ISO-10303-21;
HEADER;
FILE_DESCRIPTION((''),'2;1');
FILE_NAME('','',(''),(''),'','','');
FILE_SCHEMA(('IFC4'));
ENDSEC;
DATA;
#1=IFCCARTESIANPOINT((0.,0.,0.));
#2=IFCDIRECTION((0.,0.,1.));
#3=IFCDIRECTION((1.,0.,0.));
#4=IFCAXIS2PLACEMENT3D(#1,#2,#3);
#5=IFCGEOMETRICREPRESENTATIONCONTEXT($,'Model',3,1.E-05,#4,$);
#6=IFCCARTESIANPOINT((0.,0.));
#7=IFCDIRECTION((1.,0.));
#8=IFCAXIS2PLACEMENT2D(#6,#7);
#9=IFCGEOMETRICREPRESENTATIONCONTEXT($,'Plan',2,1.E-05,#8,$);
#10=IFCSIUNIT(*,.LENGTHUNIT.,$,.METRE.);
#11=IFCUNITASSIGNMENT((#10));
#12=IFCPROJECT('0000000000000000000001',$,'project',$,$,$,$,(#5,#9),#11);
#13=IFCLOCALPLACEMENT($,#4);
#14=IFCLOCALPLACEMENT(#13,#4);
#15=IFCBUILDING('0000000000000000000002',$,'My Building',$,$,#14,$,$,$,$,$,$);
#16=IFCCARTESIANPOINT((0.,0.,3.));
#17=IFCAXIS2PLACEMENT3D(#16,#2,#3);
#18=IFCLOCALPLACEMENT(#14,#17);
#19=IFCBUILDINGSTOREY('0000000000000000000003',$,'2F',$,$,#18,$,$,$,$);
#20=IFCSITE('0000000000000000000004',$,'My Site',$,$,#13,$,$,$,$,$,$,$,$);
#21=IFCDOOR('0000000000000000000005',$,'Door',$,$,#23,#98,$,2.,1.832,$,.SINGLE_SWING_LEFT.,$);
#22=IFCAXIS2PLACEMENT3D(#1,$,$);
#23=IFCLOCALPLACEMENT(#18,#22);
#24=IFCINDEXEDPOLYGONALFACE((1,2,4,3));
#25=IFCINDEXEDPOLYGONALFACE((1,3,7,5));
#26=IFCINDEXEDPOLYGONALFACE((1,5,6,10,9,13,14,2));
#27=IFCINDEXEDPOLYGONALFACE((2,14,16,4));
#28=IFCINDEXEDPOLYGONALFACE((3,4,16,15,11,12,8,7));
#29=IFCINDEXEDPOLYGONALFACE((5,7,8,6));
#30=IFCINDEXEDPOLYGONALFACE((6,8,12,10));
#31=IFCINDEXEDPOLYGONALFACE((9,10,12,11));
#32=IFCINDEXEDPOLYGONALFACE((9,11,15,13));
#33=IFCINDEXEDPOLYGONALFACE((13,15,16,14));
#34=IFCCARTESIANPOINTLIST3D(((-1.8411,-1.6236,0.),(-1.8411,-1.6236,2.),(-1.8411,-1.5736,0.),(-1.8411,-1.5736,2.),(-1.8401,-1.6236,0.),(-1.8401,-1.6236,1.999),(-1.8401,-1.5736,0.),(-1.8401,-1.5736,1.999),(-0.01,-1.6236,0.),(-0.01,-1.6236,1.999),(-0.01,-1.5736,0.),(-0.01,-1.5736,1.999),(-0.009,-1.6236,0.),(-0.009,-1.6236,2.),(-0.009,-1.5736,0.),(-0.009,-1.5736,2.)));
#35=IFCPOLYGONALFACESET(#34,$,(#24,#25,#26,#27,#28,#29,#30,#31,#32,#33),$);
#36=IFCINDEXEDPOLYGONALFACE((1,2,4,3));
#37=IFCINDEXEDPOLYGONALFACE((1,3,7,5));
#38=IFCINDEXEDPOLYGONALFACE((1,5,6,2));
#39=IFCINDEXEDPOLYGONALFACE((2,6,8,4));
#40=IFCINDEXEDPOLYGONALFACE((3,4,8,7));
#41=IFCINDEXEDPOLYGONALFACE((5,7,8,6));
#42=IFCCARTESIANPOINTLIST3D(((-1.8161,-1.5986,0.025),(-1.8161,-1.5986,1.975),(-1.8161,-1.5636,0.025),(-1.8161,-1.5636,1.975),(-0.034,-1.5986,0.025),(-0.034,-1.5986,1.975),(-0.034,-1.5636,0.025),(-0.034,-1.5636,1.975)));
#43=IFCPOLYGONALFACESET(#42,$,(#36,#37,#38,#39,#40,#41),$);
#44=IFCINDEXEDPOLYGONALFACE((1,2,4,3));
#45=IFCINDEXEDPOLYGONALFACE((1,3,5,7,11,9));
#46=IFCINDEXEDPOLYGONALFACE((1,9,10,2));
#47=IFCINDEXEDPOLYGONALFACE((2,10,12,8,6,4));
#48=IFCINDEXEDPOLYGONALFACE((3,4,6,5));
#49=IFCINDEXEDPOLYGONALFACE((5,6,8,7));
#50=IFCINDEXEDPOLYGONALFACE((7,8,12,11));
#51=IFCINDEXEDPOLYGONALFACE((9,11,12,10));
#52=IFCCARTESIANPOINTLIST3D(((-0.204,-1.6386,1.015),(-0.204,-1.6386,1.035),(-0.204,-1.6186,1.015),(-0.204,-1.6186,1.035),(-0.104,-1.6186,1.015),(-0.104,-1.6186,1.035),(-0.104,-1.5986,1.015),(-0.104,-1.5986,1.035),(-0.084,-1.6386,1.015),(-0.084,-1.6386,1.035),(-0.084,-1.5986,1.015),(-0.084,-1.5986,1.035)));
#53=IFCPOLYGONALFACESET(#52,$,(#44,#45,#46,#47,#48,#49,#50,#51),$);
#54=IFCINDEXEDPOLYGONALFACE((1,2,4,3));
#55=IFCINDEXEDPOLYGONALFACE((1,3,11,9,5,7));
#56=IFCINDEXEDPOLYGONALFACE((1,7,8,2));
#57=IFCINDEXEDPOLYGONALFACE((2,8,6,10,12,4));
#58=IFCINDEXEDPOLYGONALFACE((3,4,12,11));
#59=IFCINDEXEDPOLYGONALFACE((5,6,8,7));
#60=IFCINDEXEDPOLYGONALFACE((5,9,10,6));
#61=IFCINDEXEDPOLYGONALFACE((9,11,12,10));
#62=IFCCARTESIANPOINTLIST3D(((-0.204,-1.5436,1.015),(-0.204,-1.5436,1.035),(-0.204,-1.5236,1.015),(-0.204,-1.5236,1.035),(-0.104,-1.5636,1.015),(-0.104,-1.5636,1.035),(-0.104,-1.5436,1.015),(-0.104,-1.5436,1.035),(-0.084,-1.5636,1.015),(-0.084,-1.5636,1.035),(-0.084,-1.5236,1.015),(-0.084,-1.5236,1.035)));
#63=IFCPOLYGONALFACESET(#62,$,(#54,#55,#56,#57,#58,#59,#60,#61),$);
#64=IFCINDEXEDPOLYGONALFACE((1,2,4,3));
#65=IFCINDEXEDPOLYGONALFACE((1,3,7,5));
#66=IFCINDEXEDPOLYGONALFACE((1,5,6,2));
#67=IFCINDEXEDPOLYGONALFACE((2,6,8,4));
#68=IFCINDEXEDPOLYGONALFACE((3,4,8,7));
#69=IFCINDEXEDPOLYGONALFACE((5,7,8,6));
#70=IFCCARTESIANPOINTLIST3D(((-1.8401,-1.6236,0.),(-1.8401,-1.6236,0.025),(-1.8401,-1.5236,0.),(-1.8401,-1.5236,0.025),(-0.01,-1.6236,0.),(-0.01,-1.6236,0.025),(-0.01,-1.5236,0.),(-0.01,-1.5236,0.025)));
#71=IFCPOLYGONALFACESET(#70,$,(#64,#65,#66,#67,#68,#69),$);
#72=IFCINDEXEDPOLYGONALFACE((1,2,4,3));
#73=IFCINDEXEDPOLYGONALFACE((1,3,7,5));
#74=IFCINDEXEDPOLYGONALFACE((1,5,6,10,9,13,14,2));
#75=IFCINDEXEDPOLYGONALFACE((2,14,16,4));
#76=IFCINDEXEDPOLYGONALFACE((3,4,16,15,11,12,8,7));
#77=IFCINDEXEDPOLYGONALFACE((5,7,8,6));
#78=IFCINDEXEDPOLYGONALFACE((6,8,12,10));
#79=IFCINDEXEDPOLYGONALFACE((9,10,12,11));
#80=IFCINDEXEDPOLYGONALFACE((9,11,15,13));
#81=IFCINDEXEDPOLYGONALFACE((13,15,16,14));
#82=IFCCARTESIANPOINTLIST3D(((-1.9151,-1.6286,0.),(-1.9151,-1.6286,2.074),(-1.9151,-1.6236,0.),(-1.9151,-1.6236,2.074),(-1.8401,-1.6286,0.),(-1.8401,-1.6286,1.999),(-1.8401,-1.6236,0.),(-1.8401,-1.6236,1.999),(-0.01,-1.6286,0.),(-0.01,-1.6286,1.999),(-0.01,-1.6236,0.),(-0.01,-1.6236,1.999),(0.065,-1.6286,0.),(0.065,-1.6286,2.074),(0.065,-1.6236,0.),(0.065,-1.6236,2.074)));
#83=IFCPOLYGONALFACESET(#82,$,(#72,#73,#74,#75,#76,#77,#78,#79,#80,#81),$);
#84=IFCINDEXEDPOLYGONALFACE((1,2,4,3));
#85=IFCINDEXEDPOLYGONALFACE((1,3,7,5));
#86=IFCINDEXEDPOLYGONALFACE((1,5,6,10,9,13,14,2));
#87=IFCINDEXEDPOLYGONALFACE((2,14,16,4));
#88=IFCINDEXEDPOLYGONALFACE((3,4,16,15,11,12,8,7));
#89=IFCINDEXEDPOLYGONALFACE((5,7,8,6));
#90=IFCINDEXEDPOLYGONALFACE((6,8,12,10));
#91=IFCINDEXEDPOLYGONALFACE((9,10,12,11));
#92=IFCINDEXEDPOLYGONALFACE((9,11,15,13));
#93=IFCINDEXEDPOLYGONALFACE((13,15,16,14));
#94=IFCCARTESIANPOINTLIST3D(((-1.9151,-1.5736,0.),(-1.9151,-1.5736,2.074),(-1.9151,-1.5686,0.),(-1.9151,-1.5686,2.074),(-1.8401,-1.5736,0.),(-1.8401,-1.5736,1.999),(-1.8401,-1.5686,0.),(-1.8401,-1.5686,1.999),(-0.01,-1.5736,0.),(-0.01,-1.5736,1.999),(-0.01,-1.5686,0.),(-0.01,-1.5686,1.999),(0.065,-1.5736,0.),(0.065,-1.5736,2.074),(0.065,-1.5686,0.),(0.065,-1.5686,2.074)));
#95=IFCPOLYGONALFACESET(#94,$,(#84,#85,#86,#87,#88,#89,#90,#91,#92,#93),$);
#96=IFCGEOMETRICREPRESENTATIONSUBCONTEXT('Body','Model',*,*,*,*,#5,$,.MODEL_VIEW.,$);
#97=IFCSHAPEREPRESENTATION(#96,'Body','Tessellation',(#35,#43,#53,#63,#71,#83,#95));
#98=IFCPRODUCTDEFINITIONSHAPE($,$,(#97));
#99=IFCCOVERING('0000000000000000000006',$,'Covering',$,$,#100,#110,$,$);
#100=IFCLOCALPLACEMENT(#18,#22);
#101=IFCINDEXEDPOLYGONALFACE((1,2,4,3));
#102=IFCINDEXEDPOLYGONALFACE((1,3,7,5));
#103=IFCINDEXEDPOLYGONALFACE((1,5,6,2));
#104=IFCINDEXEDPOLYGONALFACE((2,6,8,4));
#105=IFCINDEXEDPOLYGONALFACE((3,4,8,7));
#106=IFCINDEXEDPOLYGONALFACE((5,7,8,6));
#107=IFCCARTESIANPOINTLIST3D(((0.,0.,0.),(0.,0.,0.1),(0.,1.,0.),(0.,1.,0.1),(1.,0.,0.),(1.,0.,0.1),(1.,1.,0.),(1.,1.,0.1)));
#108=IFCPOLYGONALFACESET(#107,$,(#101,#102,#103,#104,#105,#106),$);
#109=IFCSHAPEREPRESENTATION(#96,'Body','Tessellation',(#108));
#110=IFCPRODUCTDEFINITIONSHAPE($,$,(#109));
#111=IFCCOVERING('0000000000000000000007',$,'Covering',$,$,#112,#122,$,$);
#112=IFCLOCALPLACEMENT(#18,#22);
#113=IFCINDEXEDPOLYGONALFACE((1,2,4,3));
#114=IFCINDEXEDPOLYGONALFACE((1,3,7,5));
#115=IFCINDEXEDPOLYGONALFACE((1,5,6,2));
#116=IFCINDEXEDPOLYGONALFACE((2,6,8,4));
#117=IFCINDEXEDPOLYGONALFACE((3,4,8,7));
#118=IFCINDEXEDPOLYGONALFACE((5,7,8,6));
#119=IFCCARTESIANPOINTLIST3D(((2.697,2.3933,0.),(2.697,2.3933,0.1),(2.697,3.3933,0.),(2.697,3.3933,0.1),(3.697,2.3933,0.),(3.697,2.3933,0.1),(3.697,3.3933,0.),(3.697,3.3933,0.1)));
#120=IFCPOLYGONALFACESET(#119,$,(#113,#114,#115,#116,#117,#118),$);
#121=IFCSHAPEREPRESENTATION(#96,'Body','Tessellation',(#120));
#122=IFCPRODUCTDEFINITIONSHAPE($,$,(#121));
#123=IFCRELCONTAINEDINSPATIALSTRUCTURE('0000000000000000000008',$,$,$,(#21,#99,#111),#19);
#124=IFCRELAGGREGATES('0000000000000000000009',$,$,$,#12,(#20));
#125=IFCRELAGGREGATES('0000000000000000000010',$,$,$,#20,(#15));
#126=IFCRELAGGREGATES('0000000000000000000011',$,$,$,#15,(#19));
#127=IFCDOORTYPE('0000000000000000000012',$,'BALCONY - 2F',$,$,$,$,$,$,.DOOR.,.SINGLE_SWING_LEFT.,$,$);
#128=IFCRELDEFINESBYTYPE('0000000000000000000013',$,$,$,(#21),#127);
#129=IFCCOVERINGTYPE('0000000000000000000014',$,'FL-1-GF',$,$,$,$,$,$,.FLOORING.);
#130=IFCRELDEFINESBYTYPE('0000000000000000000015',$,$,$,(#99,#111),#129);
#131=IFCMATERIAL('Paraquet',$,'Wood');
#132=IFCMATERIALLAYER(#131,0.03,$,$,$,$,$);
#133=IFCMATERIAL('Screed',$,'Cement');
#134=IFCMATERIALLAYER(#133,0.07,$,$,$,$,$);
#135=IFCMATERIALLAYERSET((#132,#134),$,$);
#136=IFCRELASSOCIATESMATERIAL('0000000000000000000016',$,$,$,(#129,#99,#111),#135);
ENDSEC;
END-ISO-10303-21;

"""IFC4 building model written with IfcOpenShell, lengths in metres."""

from ifc_helpers import new_model, entity, si_unit, frame, origin_with_axes, origin_2d_with_axis, place, context, subcontext, project, spatial, line, indexed_curve, outline, extrude, shape, source, transform, mapped, material, layer, layer_set, layer_usage, type_object, type_shapes, element, save


model = new_model("IFC4")

# Units and contexts
model_context = context("Model", 3, precision=1e-05, world=origin_with_axes())
plan_context = context("Plan", 2, precision=1e-05, world=origin_2d_with_axis())
body_context_1 = subcontext(model_context, "Body", "Model", "MODEL_VIEW")
body_context_2 = subcontext(plan_context, "Body", "Plan", "PLAN_VIEW")
ifc_project = project(units=[si_unit("LENGTHUNIT", "METRE")], contexts=[model_context, plan_context])

# Site, building, storey
site_placement = place(None, origin_with_axes())
site = spatial("IfcSite", under=ifc_project, at=site_placement, Name="My Site")
building_placement = place(site_placement, origin_with_axes())
building = spatial("IfcBuilding", under=site, at=building_placement, Name="My Building")
storey_placement = place(building_placement, frame((0.0, 0.0, 3.0), z_axis=(0.0, 0.0, 1.0), x_axis=(1.0, 0.0, 0.0)))
storey = spatial("IfcBuildingStorey", under=building, at=storey_placement, Name="2F")

# Door
door_type_1 = type_object("IfcDoorType", Name="BALCONY - 2F", OperationType="SINGLE_SWING_LEFT", PredefinedType="DOOR")
shared_shape_1 = source(origin_with_axes(), body_context_1, "Body", "SweptSolid", [
    extrude(outline(indexed_curve([(0.0, 0.0), (0.0, 2.0), (1.832, 2.0), (1.832, 0.0), (1.831, 0.0), (1.831, 1.999), (0.001, 1.999), (0.001, 0.0)], segments=[line(1, 2, 3, 4, 5, 6, 7, 8, 1)])), frame((0.0, 0.0, 0.0), z_axis=(0.0, -1.0, 0.0), x_axis=(1.0, 0.0, 0.0)), (0.0, 0.0, -1.0), 0.05),
    extrude(outline(indexed_curve([(0.0, 0.0), (1.782, 0.0), (1.782, 0.035), (0.0, 0.035)], segments=[line(1, 2, 3, 4, 1)])), frame((0.025, 0.025, 0.025), z_axis=(0.0, 0.0, 1.0), x_axis=(1.0, 0.0, 0.0)), (0.0, 0.0, 1.0), 1.95),
    extrude(outline(indexed_curve([(0.0, 0.0), (0.0, -0.04), (-0.12, -0.04), (-0.12, -0.02), (-0.02, -0.02), (-0.02, 0.0)], segments=[line(1, 2, 3, 4, 5, 6, 1)])), frame((1.757, 0.025, 1.015), z_axis=(0.0, 0.0, 1.0), x_axis=(1.0, 0.0, 0.0)), (0.0, 0.0, 1.0), 0.02),
    extrude(outline(indexed_curve([(0.0, 0.0), (0.0, 0.04), (-0.12, 0.04), (-0.12, 0.02), (-0.02, 0.02), (-0.02, 0.0)], segments=[line(1, 2, 3, 4, 5, 6, 1)])), frame((1.757, 0.06, 1.015), z_axis=(0.0, 0.0, 1.0), x_axis=(1.0, 0.0, 0.0)), (0.0, 0.0, 1.0), 0.02),
    extrude(outline(indexed_curve([(0.0, 0.0), (1.83, 0.0), (1.83, 0.1), (0.0, 0.1)], segments=[line(1, 2, 3, 4, 1)])), frame((0.001, 0.0, 0.0), z_axis=(0.0, 0.0, 1.0), x_axis=(1.0, 0.0, 0.0)), (0.0, 0.0, 1.0), 0.025),
    extrude(outline(indexed_curve([(0.0, 0.0), (0.0, 2.074), (1.98, 2.074), (1.98, 0.0), (1.905, 0.0), (1.905, 1.999), (0.075, 1.999), (0.075, 0.0)], segments=[line(1, 2, 3, 4, 5, 6, 7, 8, 1)])), frame((-0.074, -0.005, 0.0), z_axis=(0.0, -1.0, 0.0), x_axis=(1.0, 0.0, 0.0)), (0.0, 0.0, -1.0), 0.005),
    extrude(outline(indexed_curve([(0.0, 0.0), (0.0, 2.074), (1.98, 2.074), (1.98, 0.0), (1.905, 0.0), (1.905, 1.999), (0.075, 1.999), (0.075, 0.0)], segments=[line(1, 2, 3, 4, 5, 6, 7, 8, 1)])), frame((-0.074, 0.05, 0.0), z_axis=(0.0, -1.0, 0.0), x_axis=(1.0, 0.0, 0.0)), (0.0, 0.0, -1.0), 0.005),
])
shared_shape_2 = source(origin_with_axes(), body_context_2, "Body", "Curve2D", [
    entity("IfcIndexedPolyCurve", entity("IfcCartesianPointList2D", [[0.0, 0.0], [0.001, 0.0], [0.001, 0.05], [0.0, 0.05]]), [entity("IfcLineIndex", [1, 2, 3, 4, 1])]),
    entity("IfcIndexedPolyCurve", entity("IfcCartesianPointList2D", [[1.832, 0.0], [1.831, 0.0], [1.831, 0.05], [1.832, 0.05]]), [entity("IfcLineIndex", [1, 2, 3, 4, 1])]),
    entity("IfcTrimmedCurve", entity("IfcEllipse", entity("IfcAxis2Placement2D", entity("IfcCartesianPoint", [0.06, 0.05]), entity("IfcDirection", [1.0, 0.0])), 1.747, 1.782), [entity("IfcCartesianPoint", [1.807, 0.05])], [entity("IfcCartesianPoint", [0.06, 1.832])], True, "CARTESIAN"),
    entity("IfcIndexedPolyCurve", entity("IfcCartesianPointList2D", [[0.025, 0.05], [0.06, 0.05], [0.06, 1.832], [0.025, 1.832]]), [entity("IfcLineIndex", [1, 2, 3, 4, 1])]),
])
type_shapes(door_type_1, [shared_shape_1, shared_shape_2])
door_1_placement = place(storey_placement, frame((-1.8411, -1.6236, 0.0), z_axis=(0.0, 0.0, 1.0), x_axis=(1.0, 0.0, 0.0)))
element("IfcDoor", 1, at=door_1_placement, inside=storey, type_object=door_type_1, Name="Door", OperationType="SINGLE_SWING_LEFT", OverallHeight=2.0, OverallWidth=1.832, shapes=[
    shape(body_context_1, "Body", "MappedRepresentation", [mapped(shared_shape_1, transform((0.0, 0.0, 0.0), x_axis=(1.0, 0.0, 0.0), y_axis=(0.0, 1.0, 0.0), z_axis=(0.0, 0.0, 1.0), scale=1.0))]),
    shape(body_context_2, "Body", "MappedRepresentation", [mapped(shared_shape_2, transform((0.0, 0.0, 0.0), x_axis=(1.0, 0.0, 0.0), y_axis=(0.0, 1.0, 0.0), z_axis=(0.0, 0.0, 1.0), scale=1.0))]),
])

# Coverings
ifc_material_1 = material(Name="Paraquet", Category="Wood")
ifc_layer_1 = layer(ifc_material_1, 0.03)
ifc_material_2 = material(Name="Screed", Category="Cement")
ifc_layer_2 = layer(ifc_material_2, 0.07)
ifc_layer_set_1 = layer_set([ifc_layer_1, ifc_layer_2])
ifc_layer_usage_1 = layer_usage(ifc_layer_set_1, "AXIS3", "POSITIVE", 0.0)
covering_type = type_object("IfcCoveringType", Name="FL-1-GF", PredefinedType="FLOORING", material=ifc_layer_set_1)
covering_1_placement = place(storey_placement, origin_with_axes())
element("IfcCovering", 2, at=covering_1_placement, inside=storey, type_object=covering_type, material=ifc_layer_usage_1, Name="Covering", context=body_context_1, shape_type="SweptSolid", body=[
    extrude(outline(indexed_curve([(0.0, 0.0), (1.0, 0.0), (1.0, 1.0), (0.0, 1.0), (0.0, 0.0)])), origin_with_axes(), (0.0, 0.0, 1.0), 0.1),
])
ifc_layer_usage_2 = layer_usage(ifc_layer_set_1, "AXIS3", "POSITIVE", 0.0)
covering_2_placement = place(storey_placement, frame((2.697, 2.3933, 0.0), z_axis=(0.0, 0.0, 1.0), x_axis=(1.0, 0.0, 0.0)))
element("IfcCovering", 3, at=covering_2_placement, inside=storey, type_object=covering_type, material=ifc_layer_usage_2, Name="Covering", context=body_context_1, shape_type="SweptSolid", body=[
    extrude(outline(indexed_curve([(0.0, 0.0), (1.0, 0.0), (1.0, 1.0), (0.0, 1.0), (0.0, 0.0)])), origin_with_axes(), (0.0, 0.0, 1.0), 0.1),
])

save(model, "model.ifc")
